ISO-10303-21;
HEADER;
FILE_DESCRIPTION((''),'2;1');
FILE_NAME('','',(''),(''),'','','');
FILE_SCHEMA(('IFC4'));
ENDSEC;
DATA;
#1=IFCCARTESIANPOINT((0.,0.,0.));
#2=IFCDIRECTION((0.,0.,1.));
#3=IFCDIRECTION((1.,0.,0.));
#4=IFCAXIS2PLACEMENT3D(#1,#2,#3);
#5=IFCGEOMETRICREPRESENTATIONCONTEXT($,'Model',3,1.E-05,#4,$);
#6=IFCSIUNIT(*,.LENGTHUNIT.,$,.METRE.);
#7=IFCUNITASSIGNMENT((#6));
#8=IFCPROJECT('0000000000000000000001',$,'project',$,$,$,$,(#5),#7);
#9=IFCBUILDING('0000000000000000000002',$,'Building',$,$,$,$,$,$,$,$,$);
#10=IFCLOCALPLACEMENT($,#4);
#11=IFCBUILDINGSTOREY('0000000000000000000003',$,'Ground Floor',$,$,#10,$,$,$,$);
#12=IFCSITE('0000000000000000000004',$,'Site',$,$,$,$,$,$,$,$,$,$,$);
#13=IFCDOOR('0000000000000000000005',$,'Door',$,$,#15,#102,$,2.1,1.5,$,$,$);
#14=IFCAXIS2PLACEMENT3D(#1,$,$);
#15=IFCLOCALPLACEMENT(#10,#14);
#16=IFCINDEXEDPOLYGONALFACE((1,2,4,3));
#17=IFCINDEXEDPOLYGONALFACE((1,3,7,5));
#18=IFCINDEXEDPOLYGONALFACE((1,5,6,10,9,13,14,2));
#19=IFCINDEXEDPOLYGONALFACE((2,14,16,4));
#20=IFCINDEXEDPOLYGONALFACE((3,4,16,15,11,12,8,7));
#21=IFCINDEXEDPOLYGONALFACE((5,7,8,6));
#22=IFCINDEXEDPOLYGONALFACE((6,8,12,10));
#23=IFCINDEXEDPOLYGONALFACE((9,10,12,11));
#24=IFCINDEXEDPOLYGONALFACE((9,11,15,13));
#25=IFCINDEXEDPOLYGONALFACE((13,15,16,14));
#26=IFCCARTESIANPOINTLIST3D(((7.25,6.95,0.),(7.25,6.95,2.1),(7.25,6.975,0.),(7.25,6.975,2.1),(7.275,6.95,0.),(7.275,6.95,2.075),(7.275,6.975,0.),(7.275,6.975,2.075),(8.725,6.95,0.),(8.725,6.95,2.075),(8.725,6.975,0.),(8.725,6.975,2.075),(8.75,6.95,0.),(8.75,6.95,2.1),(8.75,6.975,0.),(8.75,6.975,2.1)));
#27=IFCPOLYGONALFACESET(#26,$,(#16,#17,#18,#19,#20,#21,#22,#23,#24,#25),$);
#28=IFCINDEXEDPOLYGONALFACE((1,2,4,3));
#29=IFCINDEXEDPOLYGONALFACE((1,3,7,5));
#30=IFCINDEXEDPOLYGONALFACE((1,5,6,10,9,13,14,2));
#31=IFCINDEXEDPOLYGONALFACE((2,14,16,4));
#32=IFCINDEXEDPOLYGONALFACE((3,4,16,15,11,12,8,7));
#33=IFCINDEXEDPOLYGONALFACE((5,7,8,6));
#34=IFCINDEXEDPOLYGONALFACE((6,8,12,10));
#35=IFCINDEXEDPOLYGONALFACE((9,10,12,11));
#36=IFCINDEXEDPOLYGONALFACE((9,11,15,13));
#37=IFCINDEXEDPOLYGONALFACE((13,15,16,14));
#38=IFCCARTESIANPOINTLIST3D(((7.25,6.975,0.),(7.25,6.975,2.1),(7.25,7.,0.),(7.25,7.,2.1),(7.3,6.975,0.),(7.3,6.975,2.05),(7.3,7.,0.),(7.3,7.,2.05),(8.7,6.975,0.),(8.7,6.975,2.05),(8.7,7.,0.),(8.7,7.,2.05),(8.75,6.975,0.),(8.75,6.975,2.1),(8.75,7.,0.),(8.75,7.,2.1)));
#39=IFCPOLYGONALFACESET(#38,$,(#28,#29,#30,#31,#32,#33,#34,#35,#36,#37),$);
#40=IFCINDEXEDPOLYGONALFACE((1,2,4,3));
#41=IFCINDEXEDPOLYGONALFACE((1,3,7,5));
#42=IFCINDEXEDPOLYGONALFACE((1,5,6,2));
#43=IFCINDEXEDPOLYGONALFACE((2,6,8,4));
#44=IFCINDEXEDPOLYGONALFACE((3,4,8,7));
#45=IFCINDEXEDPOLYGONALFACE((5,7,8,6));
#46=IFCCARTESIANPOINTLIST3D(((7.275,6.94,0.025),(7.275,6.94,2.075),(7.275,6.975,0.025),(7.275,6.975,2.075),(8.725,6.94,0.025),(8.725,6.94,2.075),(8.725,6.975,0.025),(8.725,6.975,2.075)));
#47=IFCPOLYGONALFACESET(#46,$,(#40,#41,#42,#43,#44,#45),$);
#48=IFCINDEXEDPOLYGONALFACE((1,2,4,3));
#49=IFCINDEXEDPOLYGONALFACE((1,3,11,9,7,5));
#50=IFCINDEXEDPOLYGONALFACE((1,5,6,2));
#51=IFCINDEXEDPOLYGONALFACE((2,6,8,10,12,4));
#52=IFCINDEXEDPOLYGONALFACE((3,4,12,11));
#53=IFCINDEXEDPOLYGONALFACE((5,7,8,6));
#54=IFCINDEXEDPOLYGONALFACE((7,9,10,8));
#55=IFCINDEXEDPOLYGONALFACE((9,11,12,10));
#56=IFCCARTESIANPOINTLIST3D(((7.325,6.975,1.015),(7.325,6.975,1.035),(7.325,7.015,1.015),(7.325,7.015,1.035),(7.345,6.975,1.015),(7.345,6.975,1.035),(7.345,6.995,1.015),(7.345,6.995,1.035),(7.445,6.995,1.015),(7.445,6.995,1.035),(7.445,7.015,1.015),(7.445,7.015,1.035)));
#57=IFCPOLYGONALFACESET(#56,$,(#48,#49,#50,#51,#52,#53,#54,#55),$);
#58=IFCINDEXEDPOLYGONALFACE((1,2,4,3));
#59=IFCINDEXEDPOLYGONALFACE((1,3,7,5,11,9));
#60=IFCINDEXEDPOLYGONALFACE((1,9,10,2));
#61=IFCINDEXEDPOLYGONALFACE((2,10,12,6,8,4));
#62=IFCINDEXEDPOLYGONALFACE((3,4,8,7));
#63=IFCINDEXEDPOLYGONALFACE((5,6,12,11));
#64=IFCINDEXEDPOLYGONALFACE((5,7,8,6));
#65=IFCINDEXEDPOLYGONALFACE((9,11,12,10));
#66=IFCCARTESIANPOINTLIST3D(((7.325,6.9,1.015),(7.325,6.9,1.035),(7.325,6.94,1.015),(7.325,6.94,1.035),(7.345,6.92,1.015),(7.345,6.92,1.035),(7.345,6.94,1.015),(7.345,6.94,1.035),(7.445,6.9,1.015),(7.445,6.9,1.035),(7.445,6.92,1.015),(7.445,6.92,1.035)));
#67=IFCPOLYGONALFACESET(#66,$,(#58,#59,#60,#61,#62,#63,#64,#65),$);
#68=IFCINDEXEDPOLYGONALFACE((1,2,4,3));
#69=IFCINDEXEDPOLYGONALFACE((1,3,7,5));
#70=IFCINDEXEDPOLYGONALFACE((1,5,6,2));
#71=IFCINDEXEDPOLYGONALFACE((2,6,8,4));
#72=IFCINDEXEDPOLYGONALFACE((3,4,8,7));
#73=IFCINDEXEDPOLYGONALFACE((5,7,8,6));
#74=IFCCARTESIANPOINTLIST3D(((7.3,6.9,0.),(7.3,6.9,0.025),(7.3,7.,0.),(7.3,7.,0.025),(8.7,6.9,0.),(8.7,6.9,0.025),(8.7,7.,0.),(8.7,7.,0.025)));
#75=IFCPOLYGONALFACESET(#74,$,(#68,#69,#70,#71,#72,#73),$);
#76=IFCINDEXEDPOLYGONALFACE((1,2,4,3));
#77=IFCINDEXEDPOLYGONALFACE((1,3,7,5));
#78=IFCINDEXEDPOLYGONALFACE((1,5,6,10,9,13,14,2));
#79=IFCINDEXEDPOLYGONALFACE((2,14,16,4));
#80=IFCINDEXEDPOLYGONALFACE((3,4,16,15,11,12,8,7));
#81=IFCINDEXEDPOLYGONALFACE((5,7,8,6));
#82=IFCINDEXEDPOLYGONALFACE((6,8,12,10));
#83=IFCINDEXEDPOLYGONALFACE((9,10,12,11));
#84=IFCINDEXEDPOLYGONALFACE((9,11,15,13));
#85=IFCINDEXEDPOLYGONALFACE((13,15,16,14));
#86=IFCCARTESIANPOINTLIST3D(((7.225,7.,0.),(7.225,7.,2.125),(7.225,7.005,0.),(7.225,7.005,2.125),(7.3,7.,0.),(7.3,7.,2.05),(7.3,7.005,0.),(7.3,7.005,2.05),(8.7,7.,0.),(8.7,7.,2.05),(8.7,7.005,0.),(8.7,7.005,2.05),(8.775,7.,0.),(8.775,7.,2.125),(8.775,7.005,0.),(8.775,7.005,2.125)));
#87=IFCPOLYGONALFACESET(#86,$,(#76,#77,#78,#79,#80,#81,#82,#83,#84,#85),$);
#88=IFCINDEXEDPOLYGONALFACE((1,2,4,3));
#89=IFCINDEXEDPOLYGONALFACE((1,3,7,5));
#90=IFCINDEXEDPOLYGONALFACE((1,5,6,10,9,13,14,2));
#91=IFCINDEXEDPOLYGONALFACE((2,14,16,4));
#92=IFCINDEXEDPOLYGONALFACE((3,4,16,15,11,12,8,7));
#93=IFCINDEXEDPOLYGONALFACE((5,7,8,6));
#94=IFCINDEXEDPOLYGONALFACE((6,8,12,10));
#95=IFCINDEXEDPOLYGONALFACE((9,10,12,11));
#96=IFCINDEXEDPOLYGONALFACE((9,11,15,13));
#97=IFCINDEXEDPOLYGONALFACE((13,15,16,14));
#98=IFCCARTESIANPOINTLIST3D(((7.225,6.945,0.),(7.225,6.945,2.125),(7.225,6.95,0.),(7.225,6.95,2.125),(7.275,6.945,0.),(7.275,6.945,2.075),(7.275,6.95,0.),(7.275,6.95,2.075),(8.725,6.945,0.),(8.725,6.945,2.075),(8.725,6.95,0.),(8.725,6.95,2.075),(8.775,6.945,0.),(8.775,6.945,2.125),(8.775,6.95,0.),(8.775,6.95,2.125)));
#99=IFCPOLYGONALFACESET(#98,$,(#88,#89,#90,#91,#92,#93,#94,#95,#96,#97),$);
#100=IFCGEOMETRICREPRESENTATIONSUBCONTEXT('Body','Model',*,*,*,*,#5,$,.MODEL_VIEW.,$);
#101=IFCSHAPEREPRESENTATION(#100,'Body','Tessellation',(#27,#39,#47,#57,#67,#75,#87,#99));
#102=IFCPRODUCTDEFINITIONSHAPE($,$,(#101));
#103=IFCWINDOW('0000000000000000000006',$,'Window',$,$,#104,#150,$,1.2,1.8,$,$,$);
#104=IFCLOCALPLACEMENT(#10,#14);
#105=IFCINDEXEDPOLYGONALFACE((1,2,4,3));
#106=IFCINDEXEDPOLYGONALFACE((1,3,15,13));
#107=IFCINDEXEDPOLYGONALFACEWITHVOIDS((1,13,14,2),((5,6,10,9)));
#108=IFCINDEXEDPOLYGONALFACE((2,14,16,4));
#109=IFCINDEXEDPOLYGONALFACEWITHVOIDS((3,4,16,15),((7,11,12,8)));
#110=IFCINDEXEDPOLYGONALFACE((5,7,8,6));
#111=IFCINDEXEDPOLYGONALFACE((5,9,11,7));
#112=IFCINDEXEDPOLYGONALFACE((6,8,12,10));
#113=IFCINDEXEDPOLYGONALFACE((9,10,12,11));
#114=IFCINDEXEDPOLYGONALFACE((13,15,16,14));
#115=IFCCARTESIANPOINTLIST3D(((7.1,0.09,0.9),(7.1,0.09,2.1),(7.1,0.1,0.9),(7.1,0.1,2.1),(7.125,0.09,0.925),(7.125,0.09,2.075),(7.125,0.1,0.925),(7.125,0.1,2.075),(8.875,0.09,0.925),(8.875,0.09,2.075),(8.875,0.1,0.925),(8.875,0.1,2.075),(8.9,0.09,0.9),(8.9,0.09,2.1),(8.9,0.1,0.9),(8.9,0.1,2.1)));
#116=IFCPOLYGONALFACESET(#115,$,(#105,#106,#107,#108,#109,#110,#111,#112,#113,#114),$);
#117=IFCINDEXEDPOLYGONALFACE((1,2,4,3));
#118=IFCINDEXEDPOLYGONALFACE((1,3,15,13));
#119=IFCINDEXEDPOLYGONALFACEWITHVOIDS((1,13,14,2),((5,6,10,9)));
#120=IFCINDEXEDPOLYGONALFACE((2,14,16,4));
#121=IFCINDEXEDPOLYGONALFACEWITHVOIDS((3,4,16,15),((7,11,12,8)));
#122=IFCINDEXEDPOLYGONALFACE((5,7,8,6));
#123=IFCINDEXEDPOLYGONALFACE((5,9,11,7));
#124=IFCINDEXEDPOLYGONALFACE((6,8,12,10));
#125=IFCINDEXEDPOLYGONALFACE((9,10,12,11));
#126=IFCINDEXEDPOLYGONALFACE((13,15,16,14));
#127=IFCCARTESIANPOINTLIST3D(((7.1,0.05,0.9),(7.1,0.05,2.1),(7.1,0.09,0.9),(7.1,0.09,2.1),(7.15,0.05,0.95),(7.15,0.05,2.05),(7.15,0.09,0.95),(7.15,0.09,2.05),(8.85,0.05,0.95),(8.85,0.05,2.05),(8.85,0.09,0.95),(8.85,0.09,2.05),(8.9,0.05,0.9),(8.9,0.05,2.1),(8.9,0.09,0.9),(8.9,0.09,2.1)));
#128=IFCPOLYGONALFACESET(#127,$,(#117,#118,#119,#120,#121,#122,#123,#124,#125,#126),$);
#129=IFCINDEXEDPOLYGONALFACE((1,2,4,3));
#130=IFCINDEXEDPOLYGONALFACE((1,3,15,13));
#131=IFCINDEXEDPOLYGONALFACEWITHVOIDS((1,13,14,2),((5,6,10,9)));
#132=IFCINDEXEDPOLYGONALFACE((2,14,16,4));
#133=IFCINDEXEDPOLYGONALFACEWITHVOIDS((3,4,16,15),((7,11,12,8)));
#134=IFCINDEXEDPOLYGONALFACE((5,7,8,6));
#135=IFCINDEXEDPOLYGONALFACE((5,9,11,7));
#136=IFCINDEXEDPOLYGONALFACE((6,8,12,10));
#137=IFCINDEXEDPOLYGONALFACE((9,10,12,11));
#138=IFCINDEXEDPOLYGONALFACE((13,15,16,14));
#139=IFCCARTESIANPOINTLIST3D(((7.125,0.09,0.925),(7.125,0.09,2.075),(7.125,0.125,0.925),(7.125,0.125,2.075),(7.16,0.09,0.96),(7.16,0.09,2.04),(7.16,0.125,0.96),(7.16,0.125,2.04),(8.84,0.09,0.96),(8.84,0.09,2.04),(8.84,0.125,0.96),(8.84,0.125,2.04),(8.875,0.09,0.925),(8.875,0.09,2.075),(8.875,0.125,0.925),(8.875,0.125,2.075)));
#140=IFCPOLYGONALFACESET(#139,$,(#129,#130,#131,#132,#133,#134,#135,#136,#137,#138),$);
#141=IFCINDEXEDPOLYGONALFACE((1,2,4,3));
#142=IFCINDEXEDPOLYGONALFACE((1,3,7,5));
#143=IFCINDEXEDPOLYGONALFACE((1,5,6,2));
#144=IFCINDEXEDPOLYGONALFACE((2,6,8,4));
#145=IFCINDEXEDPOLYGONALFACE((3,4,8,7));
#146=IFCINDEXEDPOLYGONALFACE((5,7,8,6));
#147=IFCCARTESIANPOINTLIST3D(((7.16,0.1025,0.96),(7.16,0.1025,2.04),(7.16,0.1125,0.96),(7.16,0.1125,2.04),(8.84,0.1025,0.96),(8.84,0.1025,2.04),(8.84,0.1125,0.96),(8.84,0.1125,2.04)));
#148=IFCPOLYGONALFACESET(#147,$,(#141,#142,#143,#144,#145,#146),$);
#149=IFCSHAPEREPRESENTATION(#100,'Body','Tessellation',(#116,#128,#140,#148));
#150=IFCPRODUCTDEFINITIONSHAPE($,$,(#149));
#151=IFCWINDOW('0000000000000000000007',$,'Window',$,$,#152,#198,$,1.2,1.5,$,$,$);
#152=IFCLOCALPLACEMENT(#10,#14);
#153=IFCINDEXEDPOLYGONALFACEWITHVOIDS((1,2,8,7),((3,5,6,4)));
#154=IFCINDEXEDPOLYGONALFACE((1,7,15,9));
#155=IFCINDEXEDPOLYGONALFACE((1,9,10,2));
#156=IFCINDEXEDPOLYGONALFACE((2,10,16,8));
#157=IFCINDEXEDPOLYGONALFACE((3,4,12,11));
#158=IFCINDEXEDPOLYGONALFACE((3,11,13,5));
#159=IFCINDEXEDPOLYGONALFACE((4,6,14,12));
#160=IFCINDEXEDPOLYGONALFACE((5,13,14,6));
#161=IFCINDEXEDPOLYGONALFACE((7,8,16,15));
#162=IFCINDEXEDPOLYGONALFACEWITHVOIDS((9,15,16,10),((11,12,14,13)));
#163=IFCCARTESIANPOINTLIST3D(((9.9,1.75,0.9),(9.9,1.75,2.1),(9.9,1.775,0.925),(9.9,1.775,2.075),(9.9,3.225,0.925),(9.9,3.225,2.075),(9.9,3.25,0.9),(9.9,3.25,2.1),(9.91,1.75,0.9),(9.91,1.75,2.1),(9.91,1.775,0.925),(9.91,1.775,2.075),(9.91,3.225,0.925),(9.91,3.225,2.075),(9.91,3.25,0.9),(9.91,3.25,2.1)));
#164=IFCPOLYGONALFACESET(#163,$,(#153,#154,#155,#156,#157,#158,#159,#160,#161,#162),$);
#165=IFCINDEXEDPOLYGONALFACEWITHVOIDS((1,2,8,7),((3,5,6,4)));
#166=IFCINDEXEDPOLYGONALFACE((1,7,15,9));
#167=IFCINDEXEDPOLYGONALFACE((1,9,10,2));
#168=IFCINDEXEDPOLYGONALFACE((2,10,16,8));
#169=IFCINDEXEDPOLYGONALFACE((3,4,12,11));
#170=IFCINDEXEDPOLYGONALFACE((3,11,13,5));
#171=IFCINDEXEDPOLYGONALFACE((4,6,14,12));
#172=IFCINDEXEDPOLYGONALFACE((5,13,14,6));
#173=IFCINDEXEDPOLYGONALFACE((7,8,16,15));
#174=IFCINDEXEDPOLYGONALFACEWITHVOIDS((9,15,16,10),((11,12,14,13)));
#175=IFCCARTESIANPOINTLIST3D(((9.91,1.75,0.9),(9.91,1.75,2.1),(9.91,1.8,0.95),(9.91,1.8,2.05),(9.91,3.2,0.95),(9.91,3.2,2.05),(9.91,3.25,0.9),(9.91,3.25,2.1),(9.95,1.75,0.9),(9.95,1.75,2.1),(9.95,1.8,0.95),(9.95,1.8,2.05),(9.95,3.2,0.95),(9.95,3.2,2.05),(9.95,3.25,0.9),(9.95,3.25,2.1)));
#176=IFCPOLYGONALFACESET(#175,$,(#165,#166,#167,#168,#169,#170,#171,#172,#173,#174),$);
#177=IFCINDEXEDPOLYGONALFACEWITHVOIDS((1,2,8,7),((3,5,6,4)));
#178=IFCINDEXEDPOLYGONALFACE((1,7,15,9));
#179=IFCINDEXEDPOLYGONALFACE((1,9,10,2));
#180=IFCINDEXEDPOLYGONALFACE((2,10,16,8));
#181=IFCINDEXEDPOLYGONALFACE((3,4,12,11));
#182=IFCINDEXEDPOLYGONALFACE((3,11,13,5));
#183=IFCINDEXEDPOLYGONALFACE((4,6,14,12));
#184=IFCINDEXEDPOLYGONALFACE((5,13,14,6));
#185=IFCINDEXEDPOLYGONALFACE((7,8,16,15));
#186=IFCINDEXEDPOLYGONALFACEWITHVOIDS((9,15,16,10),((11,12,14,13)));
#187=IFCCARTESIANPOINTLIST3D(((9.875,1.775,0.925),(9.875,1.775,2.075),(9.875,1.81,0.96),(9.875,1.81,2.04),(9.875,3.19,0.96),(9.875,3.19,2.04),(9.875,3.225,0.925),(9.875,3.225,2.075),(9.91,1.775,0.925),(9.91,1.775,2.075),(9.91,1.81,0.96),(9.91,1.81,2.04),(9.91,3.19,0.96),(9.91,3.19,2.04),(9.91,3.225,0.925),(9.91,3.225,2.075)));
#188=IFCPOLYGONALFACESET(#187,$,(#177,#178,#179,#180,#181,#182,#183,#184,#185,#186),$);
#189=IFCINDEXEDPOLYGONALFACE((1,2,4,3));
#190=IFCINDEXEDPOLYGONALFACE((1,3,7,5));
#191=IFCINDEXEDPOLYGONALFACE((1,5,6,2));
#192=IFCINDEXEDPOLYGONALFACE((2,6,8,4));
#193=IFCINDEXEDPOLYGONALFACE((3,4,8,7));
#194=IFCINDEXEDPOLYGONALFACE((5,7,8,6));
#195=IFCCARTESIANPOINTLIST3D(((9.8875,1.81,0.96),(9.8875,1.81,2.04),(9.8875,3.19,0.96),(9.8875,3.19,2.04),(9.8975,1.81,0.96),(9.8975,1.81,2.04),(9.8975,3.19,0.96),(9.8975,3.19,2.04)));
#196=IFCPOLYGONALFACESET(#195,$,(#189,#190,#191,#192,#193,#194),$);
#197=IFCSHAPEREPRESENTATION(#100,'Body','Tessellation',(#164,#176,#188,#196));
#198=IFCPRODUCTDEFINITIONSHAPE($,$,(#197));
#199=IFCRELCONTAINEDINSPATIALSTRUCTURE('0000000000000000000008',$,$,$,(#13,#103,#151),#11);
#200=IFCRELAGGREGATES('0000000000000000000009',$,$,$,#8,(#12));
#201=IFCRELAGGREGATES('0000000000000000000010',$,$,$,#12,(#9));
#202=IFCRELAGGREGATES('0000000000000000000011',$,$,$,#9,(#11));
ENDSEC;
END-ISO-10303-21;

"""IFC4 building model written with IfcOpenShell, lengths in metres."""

from ifc_helpers import new_model, si_unit, frame, origin_with_axes, place, context, subcontext, project, spatial, line, indexed_curve, outline, extrude, element, save


model = new_model("IFC4")

# Units and contexts
model_context = context("Model", 3, precision=1e-05, world=origin_with_axes())
body_context = subcontext(model_context, "Body", "Model", "MODEL_VIEW")
ifc_project = project(units=[si_unit("LENGTHUNIT", "METRE")], contexts=[model_context])

# Site, building, storey
site = spatial("IfcSite", under=ifc_project, Name="Site")
building = spatial("IfcBuilding", under=site, Name="Building")
storey_placement = place(None, origin_with_axes())
storey = spatial("IfcBuildingStorey", under=building, at=storey_placement, Name="Ground Floor")

# Door
door_1_placement = place(storey_placement, frame((8.75, 7.0, 0.0), z_axis=(0.0, 0.0, 1.0), x_axis=(-1.0, 0.0, 0.0)))
element("IfcDoor", 1, at=door_1_placement, inside=storey, Name="Door", OverallHeight=2.1, OverallWidth=1.5, context=body_context, shape_type="SweptSolid", body=[
    extrude(outline(indexed_curve([(0.0, 0.0), (0.0, 2.1), (1.5, 2.1), (1.5, 0.0), (1.475, 0.0), (1.475, 2.075), (0.025, 2.075), (0.025, 0.0)], segments=[line(1, 2, 3, 4, 5, 6, 7, 8, 1)])), frame((0.0, 0.025, 0.0), z_axis=(0.0, -1.0, 0.0), x_axis=(1.0, 0.0, 0.0)), (0.0, 0.0, -1.0), 0.025),
    extrude(outline(indexed_curve([(0.0, 0.0), (0.0, 2.1), (1.5, 2.1), (1.5, 0.0), (1.45, 0.0), (1.45, 2.05), (0.05, 2.05), (0.05, 0.0)], segments=[line(1, 2, 3, 4, 5, 6, 7, 8, 1)])), frame((0.0, 0.0, 0.0), z_axis=(0.0, -1.0, 0.0), x_axis=(1.0, 0.0, 0.0)), (0.0, 0.0, -1.0), 0.025),
    extrude(outline(indexed_curve([(0.0, 0.0), (1.45, 0.0), (1.45, 0.035), (0.0, 0.035)], segments=[line(1, 2, 3, 4, 1)])), frame((0.025, 0.025, 0.025), z_axis=(0.0, 0.0, 1.0), x_axis=(1.0, 0.0, 0.0)), (0.0, 0.0, 1.0), 2.05),
    extrude(outline(indexed_curve([(0.0, 0.0), (0.0, -0.04), (-0.12, -0.04), (-0.12, -0.02), (-0.02, -0.02), (-0.02, 0.0)], segments=[line(1, 2, 3, 4, 5, 6, 1)])), frame((1.425, 0.025, 1.015), z_axis=(0.0, 0.0, 1.0), x_axis=(1.0, 0.0, 0.0)), (0.0, 0.0, 1.0), 0.02),
    extrude(outline(indexed_curve([(0.0, 0.0), (0.0, 0.04), (-0.12, 0.04), (-0.12, 0.02), (-0.02, 0.02), (-0.02, 0.0)], segments=[line(1, 2, 3, 4, 5, 6, 1)])), frame((1.425, 0.06, 1.015), z_axis=(0.0, 0.0, 1.0), x_axis=(1.0, 0.0, 0.0)), (0.0, 0.0, 1.0), 0.02),
    extrude(outline(indexed_curve([(0.0, 0.0), (1.4, 0.0), (1.4, 0.1), (0.0, 0.1)], segments=[line(1, 2, 3, 4, 1)])), frame((0.05, 0.0, 0.0), z_axis=(0.0, 0.0, 1.0), x_axis=(1.0, 0.0, 0.0)), (0.0, 0.0, 1.0), 0.025),
    extrude(outline(indexed_curve([(0.0, 0.0), (0.0, 2.125), (1.55, 2.125), (1.55, 0.0), (1.475, 0.0), (1.475, 2.05), (0.075, 2.05), (0.075, 0.0)], segments=[line(1, 2, 3, 4, 5, 6, 7, 8, 1)])), frame((-0.025, -0.005, 0.0), z_axis=(0.0, -1.0, 0.0), x_axis=(1.0, 0.0, 0.0)), (0.0, 0.0, -1.0), 0.005),
    extrude(outline(indexed_curve([(0.0, 0.0), (0.0, 2.125), (1.55, 2.125), (1.55, 0.0), (1.5, 0.0), (1.5, 2.075), (0.05, 2.075), (0.05, 0.0)], segments=[line(1, 2, 3, 4, 5, 6, 7, 8, 1)])), frame((-0.025, 0.05, 0.0), z_axis=(0.0, -1.0, 0.0), x_axis=(1.0, 0.0, 0.0)), (0.0, 0.0, -1.0), 0.005),
])

# Windows
window_1_placement = place(storey_placement, frame((7.1, 0.0, 0.9), z_axis=(0.0, 0.0, 1.0), x_axis=(1.0, 0.0, 0.0)))
element("IfcWindow", 2, at=window_1_placement, inside=storey, Name="Window", OverallHeight=1.2, OverallWidth=1.8, context=body_context, shape_type="SweptSolid", body=[
    extrude(outline(indexed_curve([(0.0, 0.0), (1.8, 0.0), (1.8, 1.2), (0.0, 1.2)], segments=[line(1, 2, 3, 4, 1)]), holes=[indexed_curve([(0.025, 0.025), (1.775, 0.025), (1.775, 1.175), (0.025, 1.175)], segments=[line(1, 2, 3, 4, 1)])]), frame((0.0, 0.09, 0.0), z_axis=(0.0, -1.0, 0.0), x_axis=(1.0, 0.0, 0.0)), (0.0, 0.0, -1.0), 0.01),
    extrude(outline(indexed_curve([(0.0, 0.0), (1.8, 0.0), (1.8, 1.2), (0.0, 1.2)], segments=[line(1, 2, 3, 4, 1)]), holes=[indexed_curve([(0.05, 0.05), (1.75, 0.05), (1.75, 1.15), (0.05, 1.15)], segments=[line(1, 2, 3, 4, 1)])]), frame((0.0, 0.05, 0.0), z_axis=(0.0, -1.0, 0.0), x_axis=(1.0, 0.0, 0.0)), (0.0, 0.0, -1.0), 0.04),
    extrude(outline(indexed_curve([(0.0, 0.0), (1.75, 0.0), (1.75, 1.15), (0.0, 1.15)], segments=[line(1, 2, 3, 4, 1)]), holes=[indexed_curve([(0.035, 0.035), (1.715, 0.035), (1.715, 1.115), (0.035, 1.115)], segments=[line(1, 2, 3, 4, 1)])]), frame((0.025, 0.09, 0.025), z_axis=(0.0, -1.0, 0.0), x_axis=(1.0, 0.0, 0.0)), (0.0, 0.0, -1.0), 0.035),
    extrude(outline(indexed_curve([(0.035, 0.035), (1.715, 0.035), (1.715, 1.115), (0.035, 1.115)], segments=[line(1, 2, 3, 4, 1)])), frame((0.025, 0.1025, 0.025), z_axis=(0.0, -1.0, 0.0), x_axis=(1.0, 0.0, 0.0)), (0.0, 0.0, -1.0), 0.01),
])
window_2_placement = place(storey_placement, frame((10.0, 1.75, 0.9), z_axis=(0.0, 0.0, 1.0), x_axis=(0.0, 1.0, 0.0)))
element("IfcWindow", 3, at=window_2_placement, inside=storey, Name="Window", OverallHeight=1.2, OverallWidth=1.5, context=body_context, shape_type="SweptSolid", body=[
    extrude(outline(indexed_curve([(0.0, 0.0), (1.5, 0.0), (1.5, 1.2), (0.0, 1.2)], segments=[line(1, 2, 3, 4, 1)]), holes=[indexed_curve([(0.025, 0.025), (1.475, 0.025), (1.475, 1.175), (0.025, 1.175)], segments=[line(1, 2, 3, 4, 1)])]), frame((0.0, 0.09, 0.0), z_axis=(0.0, -1.0, 0.0), x_axis=(1.0, 0.0, 0.0)), (0.0, 0.0, -1.0), 0.01),
    extrude(outline(indexed_curve([(0.0, 0.0), (1.5, 0.0), (1.5, 1.2), (0.0, 1.2)], segments=[line(1, 2, 3, 4, 1)]), holes=[indexed_curve([(0.05, 0.05), (1.45, 0.05), (1.45, 1.15), (0.05, 1.15)], segments=[line(1, 2, 3, 4, 1)])]), frame((0.0, 0.05, 0.0), z_axis=(0.0, -1.0, 0.0), x_axis=(1.0, 0.0, 0.0)), (0.0, 0.0, -1.0), 0.04),
    extrude(outline(indexed_curve([(0.0, 0.0), (1.45, 0.0), (1.45, 1.15), (0.0, 1.15)], segments=[line(1, 2, 3, 4, 1)]), holes=[indexed_curve([(0.035, 0.035), (1.415, 0.035), (1.415, 1.115), (0.035, 1.115)], segments=[line(1, 2, 3, 4, 1)])]), frame((0.025, 0.09, 0.025), z_axis=(0.0, -1.0, 0.0), x_axis=(1.0, 0.0, 0.0)), (0.0, 0.0, -1.0), 0.035),
    extrude(outline(indexed_curve([(0.035, 0.035), (1.415, 0.035), (1.415, 1.115), (0.035, 1.115)], segments=[line(1, 2, 3, 4, 1)])), frame((0.025, 0.1025, 0.025), z_axis=(0.0, -1.0, 0.0), x_axis=(1.0, 0.0, 0.0)), (0.0, 0.0, -1.0), 0.01),
])

save(model, "model.ifc")
